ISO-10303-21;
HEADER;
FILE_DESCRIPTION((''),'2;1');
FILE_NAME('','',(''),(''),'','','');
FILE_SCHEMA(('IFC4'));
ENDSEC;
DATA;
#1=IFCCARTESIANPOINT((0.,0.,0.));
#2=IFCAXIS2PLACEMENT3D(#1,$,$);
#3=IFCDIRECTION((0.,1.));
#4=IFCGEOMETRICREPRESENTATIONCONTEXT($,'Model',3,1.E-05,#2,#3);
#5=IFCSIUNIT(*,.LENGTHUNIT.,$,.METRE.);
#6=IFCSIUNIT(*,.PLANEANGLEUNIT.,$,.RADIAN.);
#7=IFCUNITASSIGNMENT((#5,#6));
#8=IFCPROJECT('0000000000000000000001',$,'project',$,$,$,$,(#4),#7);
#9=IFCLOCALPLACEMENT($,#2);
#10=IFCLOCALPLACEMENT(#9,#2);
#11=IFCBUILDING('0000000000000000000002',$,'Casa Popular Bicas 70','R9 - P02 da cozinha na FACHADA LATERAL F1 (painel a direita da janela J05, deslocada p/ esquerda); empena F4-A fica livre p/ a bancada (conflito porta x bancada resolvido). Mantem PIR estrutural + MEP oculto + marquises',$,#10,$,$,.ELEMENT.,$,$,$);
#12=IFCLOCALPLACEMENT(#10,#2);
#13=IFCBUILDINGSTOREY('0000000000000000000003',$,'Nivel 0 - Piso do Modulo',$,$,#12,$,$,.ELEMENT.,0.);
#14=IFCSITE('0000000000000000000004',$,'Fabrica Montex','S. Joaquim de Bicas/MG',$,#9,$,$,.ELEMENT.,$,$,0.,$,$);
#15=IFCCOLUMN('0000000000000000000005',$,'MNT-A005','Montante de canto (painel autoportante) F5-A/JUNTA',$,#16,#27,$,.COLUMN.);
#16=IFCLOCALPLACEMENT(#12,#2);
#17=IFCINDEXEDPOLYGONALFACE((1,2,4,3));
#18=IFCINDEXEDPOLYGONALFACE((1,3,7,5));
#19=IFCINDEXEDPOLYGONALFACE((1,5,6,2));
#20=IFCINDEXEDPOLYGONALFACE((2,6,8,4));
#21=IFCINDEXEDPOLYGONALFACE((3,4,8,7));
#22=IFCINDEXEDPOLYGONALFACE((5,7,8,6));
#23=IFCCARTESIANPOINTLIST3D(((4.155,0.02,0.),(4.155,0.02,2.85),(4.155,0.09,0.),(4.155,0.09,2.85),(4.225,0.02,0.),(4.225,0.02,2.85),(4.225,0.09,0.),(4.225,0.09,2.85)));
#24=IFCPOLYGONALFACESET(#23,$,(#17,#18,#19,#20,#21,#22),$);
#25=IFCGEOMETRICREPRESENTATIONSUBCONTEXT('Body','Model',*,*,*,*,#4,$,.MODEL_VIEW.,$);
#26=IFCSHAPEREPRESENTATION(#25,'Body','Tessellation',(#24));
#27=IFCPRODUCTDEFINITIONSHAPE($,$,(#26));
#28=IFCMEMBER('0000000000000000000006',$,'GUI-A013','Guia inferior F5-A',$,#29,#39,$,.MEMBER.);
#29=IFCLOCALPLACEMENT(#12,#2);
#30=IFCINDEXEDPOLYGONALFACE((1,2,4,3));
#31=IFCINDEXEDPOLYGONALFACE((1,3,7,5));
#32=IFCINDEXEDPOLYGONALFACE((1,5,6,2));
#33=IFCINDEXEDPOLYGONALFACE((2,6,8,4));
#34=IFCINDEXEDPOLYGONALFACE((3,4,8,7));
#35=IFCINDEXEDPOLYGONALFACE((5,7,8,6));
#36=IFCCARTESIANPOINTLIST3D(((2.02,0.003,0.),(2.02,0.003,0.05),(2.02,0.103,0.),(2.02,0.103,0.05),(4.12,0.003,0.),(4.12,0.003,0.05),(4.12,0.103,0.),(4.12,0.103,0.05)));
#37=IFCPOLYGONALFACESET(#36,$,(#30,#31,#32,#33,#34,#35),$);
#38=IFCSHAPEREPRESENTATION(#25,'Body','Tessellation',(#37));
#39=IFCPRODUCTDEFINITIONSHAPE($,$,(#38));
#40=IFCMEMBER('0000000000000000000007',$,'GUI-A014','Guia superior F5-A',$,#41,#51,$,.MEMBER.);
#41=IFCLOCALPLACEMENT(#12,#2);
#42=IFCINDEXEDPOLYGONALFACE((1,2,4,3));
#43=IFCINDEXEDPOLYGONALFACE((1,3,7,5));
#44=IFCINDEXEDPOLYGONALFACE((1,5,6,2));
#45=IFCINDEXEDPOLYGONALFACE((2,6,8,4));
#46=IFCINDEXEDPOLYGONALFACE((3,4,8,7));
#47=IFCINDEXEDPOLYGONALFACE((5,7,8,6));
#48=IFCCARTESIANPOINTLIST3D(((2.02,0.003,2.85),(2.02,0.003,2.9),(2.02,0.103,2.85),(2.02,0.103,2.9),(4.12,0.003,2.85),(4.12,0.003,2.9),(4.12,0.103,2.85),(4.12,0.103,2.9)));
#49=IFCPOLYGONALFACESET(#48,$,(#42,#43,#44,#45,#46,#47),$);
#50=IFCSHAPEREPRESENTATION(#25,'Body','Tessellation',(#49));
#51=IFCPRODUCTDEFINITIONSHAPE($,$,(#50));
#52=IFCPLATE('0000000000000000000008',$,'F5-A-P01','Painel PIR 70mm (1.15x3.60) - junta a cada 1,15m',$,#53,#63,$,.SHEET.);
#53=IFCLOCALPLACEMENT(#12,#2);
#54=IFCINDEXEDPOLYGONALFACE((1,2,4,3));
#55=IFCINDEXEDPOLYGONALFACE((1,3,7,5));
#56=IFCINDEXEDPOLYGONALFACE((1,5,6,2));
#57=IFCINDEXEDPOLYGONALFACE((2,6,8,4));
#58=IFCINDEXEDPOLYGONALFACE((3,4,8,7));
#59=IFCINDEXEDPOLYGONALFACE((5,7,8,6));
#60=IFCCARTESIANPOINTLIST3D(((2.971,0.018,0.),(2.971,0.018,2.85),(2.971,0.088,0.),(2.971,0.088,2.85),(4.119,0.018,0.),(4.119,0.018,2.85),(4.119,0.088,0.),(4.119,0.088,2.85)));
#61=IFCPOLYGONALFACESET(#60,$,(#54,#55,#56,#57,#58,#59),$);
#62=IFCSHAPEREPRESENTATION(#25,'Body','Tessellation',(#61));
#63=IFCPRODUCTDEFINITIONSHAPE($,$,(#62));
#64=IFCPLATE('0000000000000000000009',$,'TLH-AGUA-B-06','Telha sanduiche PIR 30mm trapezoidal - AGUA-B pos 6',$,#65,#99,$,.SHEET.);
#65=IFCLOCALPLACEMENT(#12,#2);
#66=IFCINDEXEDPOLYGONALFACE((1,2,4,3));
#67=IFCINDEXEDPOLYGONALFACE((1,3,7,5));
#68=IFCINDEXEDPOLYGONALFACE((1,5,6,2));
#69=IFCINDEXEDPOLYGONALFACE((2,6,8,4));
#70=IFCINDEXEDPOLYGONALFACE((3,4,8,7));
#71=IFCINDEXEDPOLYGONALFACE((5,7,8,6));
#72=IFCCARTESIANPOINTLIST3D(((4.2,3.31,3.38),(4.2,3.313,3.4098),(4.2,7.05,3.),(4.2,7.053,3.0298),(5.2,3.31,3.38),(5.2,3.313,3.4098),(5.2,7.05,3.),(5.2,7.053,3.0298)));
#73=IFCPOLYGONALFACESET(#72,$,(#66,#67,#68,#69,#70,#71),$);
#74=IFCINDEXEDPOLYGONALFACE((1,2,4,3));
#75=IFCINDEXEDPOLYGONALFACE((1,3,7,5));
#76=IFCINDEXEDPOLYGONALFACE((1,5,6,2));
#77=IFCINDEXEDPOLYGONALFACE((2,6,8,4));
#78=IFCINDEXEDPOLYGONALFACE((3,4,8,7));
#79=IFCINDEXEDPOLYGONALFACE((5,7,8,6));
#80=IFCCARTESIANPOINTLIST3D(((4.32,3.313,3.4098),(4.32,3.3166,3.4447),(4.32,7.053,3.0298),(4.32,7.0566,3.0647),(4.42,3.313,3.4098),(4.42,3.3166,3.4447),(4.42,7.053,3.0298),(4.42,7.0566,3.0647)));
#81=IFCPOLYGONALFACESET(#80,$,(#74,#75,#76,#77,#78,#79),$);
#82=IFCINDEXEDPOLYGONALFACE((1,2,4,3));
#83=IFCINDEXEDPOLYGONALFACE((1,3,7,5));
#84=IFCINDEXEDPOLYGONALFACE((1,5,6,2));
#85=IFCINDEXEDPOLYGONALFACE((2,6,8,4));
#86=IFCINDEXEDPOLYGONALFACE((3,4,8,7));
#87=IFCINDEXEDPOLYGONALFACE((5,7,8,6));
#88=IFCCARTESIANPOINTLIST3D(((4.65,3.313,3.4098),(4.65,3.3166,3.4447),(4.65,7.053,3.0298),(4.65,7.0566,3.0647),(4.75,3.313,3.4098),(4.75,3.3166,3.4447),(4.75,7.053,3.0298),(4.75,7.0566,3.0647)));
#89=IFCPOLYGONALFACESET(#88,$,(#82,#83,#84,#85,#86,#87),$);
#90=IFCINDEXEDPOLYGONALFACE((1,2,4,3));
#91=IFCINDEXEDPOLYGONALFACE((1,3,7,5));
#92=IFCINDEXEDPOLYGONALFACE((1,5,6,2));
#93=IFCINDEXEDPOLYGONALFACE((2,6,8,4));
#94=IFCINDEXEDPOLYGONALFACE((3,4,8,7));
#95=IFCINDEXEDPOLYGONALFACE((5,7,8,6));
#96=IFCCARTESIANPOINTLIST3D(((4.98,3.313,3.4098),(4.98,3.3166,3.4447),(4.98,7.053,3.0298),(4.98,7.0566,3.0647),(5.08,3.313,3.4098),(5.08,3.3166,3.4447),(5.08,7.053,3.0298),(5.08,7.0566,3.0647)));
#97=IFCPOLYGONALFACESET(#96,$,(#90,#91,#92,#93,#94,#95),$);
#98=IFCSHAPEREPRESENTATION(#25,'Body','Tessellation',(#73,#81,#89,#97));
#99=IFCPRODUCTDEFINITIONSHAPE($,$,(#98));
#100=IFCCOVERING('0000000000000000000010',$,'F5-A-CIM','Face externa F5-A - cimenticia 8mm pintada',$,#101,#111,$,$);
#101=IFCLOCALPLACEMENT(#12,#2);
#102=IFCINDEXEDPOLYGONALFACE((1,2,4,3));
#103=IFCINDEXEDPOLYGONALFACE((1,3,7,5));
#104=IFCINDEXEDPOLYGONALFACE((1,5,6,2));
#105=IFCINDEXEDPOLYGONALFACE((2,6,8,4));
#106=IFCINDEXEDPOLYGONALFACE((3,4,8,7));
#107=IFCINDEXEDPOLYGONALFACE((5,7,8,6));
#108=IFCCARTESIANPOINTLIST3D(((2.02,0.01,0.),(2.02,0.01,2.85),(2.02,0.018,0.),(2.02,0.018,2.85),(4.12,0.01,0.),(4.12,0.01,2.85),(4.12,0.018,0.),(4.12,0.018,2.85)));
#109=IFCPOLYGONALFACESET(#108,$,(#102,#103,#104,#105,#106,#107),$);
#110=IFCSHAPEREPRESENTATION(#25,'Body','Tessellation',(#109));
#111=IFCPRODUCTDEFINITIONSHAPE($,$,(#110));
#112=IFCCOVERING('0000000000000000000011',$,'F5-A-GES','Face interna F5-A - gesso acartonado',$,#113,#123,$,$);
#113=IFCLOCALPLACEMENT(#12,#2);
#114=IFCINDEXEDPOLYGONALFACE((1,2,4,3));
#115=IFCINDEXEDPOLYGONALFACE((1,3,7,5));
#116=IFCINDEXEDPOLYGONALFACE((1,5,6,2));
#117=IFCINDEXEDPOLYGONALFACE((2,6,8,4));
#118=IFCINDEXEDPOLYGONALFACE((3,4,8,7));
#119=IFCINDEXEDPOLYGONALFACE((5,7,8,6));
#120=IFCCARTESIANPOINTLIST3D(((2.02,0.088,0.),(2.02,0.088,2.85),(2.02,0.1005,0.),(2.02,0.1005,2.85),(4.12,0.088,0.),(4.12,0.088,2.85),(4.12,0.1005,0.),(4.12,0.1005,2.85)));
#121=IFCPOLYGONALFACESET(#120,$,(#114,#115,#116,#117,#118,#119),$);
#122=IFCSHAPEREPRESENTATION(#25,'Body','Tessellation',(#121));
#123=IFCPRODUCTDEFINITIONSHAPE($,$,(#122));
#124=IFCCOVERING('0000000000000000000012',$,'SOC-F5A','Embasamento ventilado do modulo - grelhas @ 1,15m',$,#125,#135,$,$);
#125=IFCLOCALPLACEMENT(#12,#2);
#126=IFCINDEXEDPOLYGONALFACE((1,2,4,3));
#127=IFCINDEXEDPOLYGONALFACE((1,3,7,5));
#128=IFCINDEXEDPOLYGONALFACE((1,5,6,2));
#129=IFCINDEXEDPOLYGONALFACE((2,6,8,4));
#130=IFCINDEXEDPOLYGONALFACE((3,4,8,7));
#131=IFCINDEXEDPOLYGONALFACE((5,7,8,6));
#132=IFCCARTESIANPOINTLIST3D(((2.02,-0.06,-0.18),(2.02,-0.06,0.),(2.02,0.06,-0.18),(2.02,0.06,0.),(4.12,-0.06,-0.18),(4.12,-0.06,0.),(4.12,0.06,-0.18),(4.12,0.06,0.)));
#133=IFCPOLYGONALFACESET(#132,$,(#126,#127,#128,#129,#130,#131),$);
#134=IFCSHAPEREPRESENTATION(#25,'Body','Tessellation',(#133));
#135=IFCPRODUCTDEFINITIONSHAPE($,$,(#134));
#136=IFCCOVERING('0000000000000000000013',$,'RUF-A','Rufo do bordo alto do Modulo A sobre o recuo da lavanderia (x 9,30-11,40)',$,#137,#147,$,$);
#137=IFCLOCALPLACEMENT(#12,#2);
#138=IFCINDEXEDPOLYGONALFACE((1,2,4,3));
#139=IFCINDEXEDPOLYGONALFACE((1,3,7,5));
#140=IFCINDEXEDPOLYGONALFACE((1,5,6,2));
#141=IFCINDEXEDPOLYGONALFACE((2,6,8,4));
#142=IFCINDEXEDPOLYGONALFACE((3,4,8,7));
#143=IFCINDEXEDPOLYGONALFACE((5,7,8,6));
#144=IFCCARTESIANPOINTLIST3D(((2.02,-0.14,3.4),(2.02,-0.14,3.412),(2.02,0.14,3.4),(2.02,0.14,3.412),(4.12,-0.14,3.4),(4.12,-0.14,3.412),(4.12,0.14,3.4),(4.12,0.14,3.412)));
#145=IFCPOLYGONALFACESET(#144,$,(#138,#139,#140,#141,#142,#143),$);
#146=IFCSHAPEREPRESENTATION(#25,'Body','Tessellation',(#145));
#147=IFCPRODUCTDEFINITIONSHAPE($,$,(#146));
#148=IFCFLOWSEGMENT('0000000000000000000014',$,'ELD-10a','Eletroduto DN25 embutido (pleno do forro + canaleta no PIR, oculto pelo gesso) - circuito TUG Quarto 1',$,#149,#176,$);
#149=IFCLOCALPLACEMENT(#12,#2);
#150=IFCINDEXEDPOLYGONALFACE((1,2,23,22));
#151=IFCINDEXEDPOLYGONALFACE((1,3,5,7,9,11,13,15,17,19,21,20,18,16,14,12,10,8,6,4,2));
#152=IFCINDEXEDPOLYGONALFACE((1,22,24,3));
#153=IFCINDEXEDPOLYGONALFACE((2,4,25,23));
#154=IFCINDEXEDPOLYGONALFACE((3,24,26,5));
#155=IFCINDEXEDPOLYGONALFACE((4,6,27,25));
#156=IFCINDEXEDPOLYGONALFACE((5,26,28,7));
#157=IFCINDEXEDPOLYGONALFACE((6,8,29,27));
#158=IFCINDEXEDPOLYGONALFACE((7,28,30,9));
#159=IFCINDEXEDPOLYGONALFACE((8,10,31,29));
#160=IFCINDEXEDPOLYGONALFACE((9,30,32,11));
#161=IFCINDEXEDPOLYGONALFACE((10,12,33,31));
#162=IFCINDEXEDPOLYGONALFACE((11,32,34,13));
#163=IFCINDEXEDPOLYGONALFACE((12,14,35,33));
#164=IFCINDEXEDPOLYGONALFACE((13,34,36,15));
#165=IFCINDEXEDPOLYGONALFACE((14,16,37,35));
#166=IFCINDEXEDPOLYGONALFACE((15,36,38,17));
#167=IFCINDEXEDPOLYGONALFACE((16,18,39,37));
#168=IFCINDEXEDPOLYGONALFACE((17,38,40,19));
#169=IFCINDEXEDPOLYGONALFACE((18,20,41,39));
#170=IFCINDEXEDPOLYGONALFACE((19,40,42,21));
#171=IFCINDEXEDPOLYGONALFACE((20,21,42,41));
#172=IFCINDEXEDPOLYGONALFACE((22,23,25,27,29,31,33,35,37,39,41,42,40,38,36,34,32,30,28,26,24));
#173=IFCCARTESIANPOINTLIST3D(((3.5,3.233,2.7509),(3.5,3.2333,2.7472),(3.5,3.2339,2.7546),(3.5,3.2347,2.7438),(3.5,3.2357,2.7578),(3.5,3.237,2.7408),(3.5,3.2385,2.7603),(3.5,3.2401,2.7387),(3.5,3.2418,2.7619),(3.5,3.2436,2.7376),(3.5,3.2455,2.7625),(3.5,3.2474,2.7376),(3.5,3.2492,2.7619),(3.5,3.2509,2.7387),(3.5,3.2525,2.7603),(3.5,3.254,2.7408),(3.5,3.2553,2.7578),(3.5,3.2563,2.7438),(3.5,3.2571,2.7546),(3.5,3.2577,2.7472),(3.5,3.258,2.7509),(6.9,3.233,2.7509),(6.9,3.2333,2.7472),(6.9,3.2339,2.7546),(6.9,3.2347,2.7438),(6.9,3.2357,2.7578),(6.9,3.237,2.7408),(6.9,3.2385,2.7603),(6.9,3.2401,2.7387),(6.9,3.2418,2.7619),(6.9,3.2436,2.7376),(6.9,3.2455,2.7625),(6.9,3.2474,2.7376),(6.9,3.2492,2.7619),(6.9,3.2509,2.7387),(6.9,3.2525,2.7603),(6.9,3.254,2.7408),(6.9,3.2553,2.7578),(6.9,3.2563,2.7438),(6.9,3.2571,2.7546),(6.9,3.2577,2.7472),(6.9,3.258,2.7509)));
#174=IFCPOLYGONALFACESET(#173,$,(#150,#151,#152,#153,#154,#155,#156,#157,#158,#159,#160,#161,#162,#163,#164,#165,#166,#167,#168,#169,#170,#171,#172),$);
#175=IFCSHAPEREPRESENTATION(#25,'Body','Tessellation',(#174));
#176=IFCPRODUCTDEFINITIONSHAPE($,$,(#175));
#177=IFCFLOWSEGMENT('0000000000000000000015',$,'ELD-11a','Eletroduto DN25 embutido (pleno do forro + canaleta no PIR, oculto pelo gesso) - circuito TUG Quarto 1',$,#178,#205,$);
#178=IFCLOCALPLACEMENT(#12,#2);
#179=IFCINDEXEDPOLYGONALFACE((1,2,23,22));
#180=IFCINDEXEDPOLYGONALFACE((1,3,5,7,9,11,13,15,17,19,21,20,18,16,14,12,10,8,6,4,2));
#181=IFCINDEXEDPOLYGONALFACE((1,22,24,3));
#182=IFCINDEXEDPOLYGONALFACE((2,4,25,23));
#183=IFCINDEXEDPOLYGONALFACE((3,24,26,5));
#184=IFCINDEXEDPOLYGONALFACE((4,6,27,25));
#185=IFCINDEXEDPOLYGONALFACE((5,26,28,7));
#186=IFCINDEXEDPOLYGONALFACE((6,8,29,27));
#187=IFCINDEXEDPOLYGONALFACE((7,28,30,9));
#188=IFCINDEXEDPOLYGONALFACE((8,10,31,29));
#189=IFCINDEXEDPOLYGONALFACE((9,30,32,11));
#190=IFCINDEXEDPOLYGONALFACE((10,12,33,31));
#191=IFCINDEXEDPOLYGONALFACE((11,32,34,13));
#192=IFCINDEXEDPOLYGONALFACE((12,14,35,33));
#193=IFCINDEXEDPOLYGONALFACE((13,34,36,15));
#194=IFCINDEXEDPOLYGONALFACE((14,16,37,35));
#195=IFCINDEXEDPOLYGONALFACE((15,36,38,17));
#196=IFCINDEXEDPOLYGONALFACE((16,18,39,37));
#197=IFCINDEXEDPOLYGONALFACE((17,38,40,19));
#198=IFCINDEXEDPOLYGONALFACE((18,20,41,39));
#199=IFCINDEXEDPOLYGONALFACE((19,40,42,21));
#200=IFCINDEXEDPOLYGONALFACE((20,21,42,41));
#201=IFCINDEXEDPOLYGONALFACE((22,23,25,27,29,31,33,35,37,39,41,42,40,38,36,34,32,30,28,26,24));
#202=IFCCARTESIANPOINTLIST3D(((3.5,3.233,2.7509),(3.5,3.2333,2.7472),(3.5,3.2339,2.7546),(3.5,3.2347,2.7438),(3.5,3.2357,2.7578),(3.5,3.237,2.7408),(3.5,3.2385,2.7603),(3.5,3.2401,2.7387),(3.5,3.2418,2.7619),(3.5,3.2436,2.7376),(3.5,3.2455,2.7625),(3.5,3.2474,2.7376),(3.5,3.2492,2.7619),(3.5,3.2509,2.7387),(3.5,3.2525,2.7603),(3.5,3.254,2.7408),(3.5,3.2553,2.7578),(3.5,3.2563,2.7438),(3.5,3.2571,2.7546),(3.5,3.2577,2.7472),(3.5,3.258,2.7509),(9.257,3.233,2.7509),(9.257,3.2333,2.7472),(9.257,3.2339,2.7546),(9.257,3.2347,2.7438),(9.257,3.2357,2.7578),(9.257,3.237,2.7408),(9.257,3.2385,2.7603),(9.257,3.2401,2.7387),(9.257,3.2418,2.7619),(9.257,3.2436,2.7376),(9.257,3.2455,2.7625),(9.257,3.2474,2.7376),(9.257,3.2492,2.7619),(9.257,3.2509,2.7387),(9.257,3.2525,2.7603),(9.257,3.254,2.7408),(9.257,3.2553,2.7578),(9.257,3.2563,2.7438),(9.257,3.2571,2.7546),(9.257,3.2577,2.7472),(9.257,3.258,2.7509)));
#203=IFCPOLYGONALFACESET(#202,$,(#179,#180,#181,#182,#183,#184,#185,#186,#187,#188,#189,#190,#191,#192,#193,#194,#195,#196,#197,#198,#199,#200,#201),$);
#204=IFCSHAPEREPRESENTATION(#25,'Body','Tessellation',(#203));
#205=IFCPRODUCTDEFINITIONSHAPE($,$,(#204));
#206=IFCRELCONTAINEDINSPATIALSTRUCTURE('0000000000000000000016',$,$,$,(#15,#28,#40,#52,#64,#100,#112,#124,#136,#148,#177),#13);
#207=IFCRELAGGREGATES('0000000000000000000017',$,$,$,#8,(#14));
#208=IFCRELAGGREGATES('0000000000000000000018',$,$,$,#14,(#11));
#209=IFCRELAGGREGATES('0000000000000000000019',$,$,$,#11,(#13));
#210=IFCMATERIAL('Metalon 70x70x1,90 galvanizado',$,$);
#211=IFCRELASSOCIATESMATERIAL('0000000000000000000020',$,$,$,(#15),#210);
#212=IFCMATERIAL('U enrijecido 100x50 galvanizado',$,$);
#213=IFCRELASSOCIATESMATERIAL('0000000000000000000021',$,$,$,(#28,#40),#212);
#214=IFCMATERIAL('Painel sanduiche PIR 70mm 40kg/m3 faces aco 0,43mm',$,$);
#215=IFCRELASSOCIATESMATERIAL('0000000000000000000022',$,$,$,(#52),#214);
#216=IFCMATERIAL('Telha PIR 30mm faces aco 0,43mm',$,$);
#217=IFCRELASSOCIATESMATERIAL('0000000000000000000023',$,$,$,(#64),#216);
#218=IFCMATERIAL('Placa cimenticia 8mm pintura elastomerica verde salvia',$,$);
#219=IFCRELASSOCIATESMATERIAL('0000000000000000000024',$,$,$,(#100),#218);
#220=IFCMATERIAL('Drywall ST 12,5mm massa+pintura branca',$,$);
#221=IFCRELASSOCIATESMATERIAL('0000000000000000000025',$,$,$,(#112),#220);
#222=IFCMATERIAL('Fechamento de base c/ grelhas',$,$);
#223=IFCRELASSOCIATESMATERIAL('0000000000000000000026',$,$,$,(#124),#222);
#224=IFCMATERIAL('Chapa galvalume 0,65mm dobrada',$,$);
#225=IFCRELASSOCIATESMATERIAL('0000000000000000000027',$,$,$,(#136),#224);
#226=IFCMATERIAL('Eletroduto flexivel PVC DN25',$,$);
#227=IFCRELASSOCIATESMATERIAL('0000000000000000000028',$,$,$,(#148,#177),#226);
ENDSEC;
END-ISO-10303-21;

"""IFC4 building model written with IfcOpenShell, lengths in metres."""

from ifc_helpers import new_model, si_unit, direction, frame, frame_2d, origin, origin_2d, place, context, subcontext, project, spatial, rectangle, circle, extrude, material, element, save


model = new_model("IFC4")

# Units and contexts
model_context = context("Model", 3, precision=1e-05, world=origin(), true_north=direction((0.0, 1.0)))
body_context = subcontext(model_context, "Body", "Model", "MODEL_VIEW")
ifc_project = project(units=[si_unit("LENGTHUNIT", "METRE"), si_unit("PLANEANGLEUNIT", "RADIAN")], contexts=[model_context])

# Site, building, storey
site_placement = place(None, origin())
site = spatial("IfcSite", under=ifc_project, at=site_placement, Name="Fabrica Montex", Description="S. Joaquim de Bicas/MG", CompositionType="ELEMENT", RefElevation=0.0)
building_placement = place(site_placement, origin())
building = spatial("IfcBuilding", under=site, at=building_placement, Name="Casa Popular Bicas 70", Description="R9 - P02 da cozinha na FACHADA LATERAL F1 (painel a direita da janela J05, deslocada p/ esquerda); empena F4-A fica livre p/ a bancada (conflito porta x bancada resolvido). Mantem PIR estrutural + MEP oculto + marquises", CompositionType="ELEMENT")
storey_placement = place(building_placement, origin())
storey = spatial("IfcBuildingStorey", under=building, at=storey_placement, Name="Nivel 0 - Piso do Modulo", CompositionType="ELEMENT", Elevation=0.0)

# Column
ifc_material_1 = material(Name="Metalon 70x70x1,90 galvanizado")
column_placement = place(None, frame((4.19, 0.055, 0.0), z_axis=(0.0, 0.0, 1.0), x_axis=(-1.0, 0.0, 0.0)))
element("IfcColumn", 1, at=column_placement, inside=storey, material=ifc_material_1, Name="MNT-A005", Description="Montante de canto (painel autoportante) F5-A/JUNTA", PredefinedType="COLUMN", context=body_context, shape_type="SweptSolid", body=[
    extrude(rectangle(XDim=0.07, YDim=0.07, at=origin_2d()), origin(), (0.0, 0.0, 1.0), 2.85),
])

# Members
ifc_material_2 = material(Name="U enrijecido 100x50 galvanizado")
for number, where, z_axis, x_axis, name, description in (
    (2, (4.12, 0.053, 0.025), (-1.0, 0.0, 0.0), (0.0, 0.0, 1.0), "GUI-A013", "Guia inferior F5-A"),
    (3, (4.12, 0.053, 2.875), (-1.0, 0.0, 0.0), (0.0, 0.0, 1.0), "GUI-A014", "Guia superior F5-A"),
):
    element("IfcMember", number, at=place(None, frame(where, z_axis=z_axis, x_axis=x_axis)), inside=storey, material=ifc_material_2, Name=name, Description=description, PredefinedType="MEMBER", context=body_context, shape_type="SweptSolid", body=[
        extrude(rectangle(XDim=0.05, YDim=0.1, at=origin_2d()), origin(), (0.0, 0.0, 1.0), 2.1),
    ])

# Plates
ifc_material_3 = material(Name="Painel sanduiche PIR 70mm 40kg/m3 faces aco 0,43mm")
plate_1_placement = place(None, frame((4.119, 0.053, 0.0), z_axis=(0.0, 0.0, 1.0), x_axis=(-1.0, 0.0, 0.0)))
element("IfcPlate", 4, at=plate_1_placement, inside=storey, material=ifc_material_3, Name="F5-A-P01", Description="Painel PIR 70mm (1.15x3.60) - junta a cada 1,15m", PredefinedType="SHEET", context=body_context, shape_type="SweptSolid", body=[
    extrude(rectangle(XDim=1.148, YDim=0.07, at=frame_2d((0.574, 0.0))), origin(), (0.0, 0.0, 1.0), 2.85),
])
ifc_material_4 = material(Name="Telha PIR 30mm faces aco 0,43mm")
plate_2_placement = place(storey_placement, frame((4.2, 3.31, 3.38), z_axis=(0.0, 0.101084, 0.994878), x_axis=(1.0, 0.0, 0.0)))
element("IfcPlate", 5, at=plate_2_placement, inside=storey, material=ifc_material_4, Name="TLH-AGUA-B-06", Description="Telha sanduiche PIR 30mm trapezoidal - AGUA-B pos 6", PredefinedType="SHEET", context=body_context, shape_type="SweptSolid", body=[
    extrude(rectangle(XDim=1.0, YDim=3.7593, at=frame_2d((0.5, 1.8796))), origin(), (0.0, 0.0, 1.0), 0.03),
    extrude(rectangle(XDim=0.1, YDim=3.7593, at=frame_2d((0.17, 1.8796))), frame((0.0, 0.0, 0.03)), (0.0, 0.0, 1.0), 0.035),
    extrude(rectangle(XDim=0.1, YDim=3.7593, at=frame_2d((0.5, 1.8796))), frame((0.0, 0.0, 0.03)), (0.0, 0.0, 1.0), 0.035),
    extrude(rectangle(XDim=0.1, YDim=3.7593, at=frame_2d((0.83, 1.8796))), frame((0.0, 0.0, 0.03)), (0.0, 0.0, 1.0), 0.035),
])

# Coverings
ifc_material_5 = material(Name="Placa cimenticia 8mm pintura elastomerica verde salvia")
covering_1_placement = place(None, frame((4.12, 0.014, 0.0), z_axis=(0.0, 0.0, 1.0), x_axis=(-1.0, 0.0, 0.0)))
element("IfcCovering", 6, at=covering_1_placement, inside=storey, material=ifc_material_5, Name="F5-A-CIM", Description="Face externa F5-A - cimenticia 8mm pintada", context=body_context, shape_type="SweptSolid", body=[
    extrude(rectangle(XDim=2.1, YDim=0.008, at=frame_2d((1.05, 0.0))), origin(), (0.0, 0.0, 1.0), 2.85),
])
ifc_material_6 = material(Name="Drywall ST 12,5mm massa+pintura branca")
covering_2_placement = place(None, frame((4.12, 0.0942, 0.0), z_axis=(0.0, 0.0, 1.0), x_axis=(-1.0, 0.0, 0.0)))
element("IfcCovering", 7, at=covering_2_placement, inside=storey, material=ifc_material_6, Name="F5-A-GES", Description="Face interna F5-A - gesso acartonado", context=body_context, shape_type="SweptSolid", body=[
    extrude(rectangle(XDim=2.1, YDim=0.0125, at=frame_2d((1.05, 0.0))), origin(), (0.0, 0.0, 1.0), 2.85),
])
ifc_material_7 = material(Name="Fechamento de base c/ grelhas")
covering_3_placement = place(None, frame((4.12, 0.0, -0.18), z_axis=(0.0, 0.0, 1.0), x_axis=(-1.0, 0.0, 0.0)))
element("IfcCovering", 8, at=covering_3_placement, inside=storey, material=ifc_material_7, Name="SOC-F5A", Description="Embasamento ventilado do modulo - grelhas @ 1,15m", context=body_context, shape_type="SweptSolid", body=[
    extrude(rectangle(XDim=2.1, YDim=0.12, at=frame_2d((1.05, 0.0))), origin(), (0.0, 0.0, 1.0), 0.18),
])
ifc_material_8 = material(Name="Chapa galvalume 0,65mm dobrada")
covering_4_placement = place(None, frame((4.12, 0.14, 3.4), z_axis=(0.0, 0.0, 1.0), x_axis=(-1.0, 0.0, 0.0)))
element("IfcCovering", 9, at=covering_4_placement, inside=storey, material=ifc_material_8, Name="RUF-A", Description="Rufo do bordo alto do Modulo A sobre o recuo da lavanderia (x 9,30-11,40)", context=body_context, shape_type="SweptSolid", body=[
    extrude(rectangle(XDim=2.1, YDim=0.28, at=frame_2d((1.05, 0.14))), origin(), (0.0, 0.0, 1.0), 0.012),
])

# Flow segments
ifc_material_9 = material(Name="Eletroduto flexivel PVC DN25")
flow_segment_1_placement = place(storey_placement, frame((3.5, 3.2455, 2.75), z_axis=(1.0, 0.0, 0.0), x_axis=(0.0, 0.0, 1.0)))
element("IfcFlowSegment", 10, at=flow_segment_1_placement, inside=storey, material=ifc_material_9, Name="ELD-10a", Description="Eletroduto DN25 embutido (pleno do forro + canaleta no PIR, oculto pelo gesso) - circuito TUG Quarto 1", context=body_context, shape_type="SweptSolid", body=[
    extrude(circle(Radius=0.0125, at=origin_2d()), origin(), (0.0, 0.0, 1.0), 3.4),
])
flow_segment_2_placement = place(storey_placement, frame((3.5, 3.2455, 2.75), z_axis=(1.0, 0.0, 0.0), x_axis=(0.0, 0.0, 1.0)))
element("IfcFlowSegment", 11, at=flow_segment_2_placement, inside=storey, material=ifc_material_9, Name="ELD-11a", Description="Eletroduto DN25 embutido (pleno do forro + canaleta no PIR, oculto pelo gesso) - circuito TUG Quarto 1", context=body_context, shape_type="SweptSolid", body=[
    extrude(circle(Radius=0.0125, at=origin_2d()), origin(), (0.0, 0.0, 1.0), 5.757),
])

save(model, "model.ifc")
